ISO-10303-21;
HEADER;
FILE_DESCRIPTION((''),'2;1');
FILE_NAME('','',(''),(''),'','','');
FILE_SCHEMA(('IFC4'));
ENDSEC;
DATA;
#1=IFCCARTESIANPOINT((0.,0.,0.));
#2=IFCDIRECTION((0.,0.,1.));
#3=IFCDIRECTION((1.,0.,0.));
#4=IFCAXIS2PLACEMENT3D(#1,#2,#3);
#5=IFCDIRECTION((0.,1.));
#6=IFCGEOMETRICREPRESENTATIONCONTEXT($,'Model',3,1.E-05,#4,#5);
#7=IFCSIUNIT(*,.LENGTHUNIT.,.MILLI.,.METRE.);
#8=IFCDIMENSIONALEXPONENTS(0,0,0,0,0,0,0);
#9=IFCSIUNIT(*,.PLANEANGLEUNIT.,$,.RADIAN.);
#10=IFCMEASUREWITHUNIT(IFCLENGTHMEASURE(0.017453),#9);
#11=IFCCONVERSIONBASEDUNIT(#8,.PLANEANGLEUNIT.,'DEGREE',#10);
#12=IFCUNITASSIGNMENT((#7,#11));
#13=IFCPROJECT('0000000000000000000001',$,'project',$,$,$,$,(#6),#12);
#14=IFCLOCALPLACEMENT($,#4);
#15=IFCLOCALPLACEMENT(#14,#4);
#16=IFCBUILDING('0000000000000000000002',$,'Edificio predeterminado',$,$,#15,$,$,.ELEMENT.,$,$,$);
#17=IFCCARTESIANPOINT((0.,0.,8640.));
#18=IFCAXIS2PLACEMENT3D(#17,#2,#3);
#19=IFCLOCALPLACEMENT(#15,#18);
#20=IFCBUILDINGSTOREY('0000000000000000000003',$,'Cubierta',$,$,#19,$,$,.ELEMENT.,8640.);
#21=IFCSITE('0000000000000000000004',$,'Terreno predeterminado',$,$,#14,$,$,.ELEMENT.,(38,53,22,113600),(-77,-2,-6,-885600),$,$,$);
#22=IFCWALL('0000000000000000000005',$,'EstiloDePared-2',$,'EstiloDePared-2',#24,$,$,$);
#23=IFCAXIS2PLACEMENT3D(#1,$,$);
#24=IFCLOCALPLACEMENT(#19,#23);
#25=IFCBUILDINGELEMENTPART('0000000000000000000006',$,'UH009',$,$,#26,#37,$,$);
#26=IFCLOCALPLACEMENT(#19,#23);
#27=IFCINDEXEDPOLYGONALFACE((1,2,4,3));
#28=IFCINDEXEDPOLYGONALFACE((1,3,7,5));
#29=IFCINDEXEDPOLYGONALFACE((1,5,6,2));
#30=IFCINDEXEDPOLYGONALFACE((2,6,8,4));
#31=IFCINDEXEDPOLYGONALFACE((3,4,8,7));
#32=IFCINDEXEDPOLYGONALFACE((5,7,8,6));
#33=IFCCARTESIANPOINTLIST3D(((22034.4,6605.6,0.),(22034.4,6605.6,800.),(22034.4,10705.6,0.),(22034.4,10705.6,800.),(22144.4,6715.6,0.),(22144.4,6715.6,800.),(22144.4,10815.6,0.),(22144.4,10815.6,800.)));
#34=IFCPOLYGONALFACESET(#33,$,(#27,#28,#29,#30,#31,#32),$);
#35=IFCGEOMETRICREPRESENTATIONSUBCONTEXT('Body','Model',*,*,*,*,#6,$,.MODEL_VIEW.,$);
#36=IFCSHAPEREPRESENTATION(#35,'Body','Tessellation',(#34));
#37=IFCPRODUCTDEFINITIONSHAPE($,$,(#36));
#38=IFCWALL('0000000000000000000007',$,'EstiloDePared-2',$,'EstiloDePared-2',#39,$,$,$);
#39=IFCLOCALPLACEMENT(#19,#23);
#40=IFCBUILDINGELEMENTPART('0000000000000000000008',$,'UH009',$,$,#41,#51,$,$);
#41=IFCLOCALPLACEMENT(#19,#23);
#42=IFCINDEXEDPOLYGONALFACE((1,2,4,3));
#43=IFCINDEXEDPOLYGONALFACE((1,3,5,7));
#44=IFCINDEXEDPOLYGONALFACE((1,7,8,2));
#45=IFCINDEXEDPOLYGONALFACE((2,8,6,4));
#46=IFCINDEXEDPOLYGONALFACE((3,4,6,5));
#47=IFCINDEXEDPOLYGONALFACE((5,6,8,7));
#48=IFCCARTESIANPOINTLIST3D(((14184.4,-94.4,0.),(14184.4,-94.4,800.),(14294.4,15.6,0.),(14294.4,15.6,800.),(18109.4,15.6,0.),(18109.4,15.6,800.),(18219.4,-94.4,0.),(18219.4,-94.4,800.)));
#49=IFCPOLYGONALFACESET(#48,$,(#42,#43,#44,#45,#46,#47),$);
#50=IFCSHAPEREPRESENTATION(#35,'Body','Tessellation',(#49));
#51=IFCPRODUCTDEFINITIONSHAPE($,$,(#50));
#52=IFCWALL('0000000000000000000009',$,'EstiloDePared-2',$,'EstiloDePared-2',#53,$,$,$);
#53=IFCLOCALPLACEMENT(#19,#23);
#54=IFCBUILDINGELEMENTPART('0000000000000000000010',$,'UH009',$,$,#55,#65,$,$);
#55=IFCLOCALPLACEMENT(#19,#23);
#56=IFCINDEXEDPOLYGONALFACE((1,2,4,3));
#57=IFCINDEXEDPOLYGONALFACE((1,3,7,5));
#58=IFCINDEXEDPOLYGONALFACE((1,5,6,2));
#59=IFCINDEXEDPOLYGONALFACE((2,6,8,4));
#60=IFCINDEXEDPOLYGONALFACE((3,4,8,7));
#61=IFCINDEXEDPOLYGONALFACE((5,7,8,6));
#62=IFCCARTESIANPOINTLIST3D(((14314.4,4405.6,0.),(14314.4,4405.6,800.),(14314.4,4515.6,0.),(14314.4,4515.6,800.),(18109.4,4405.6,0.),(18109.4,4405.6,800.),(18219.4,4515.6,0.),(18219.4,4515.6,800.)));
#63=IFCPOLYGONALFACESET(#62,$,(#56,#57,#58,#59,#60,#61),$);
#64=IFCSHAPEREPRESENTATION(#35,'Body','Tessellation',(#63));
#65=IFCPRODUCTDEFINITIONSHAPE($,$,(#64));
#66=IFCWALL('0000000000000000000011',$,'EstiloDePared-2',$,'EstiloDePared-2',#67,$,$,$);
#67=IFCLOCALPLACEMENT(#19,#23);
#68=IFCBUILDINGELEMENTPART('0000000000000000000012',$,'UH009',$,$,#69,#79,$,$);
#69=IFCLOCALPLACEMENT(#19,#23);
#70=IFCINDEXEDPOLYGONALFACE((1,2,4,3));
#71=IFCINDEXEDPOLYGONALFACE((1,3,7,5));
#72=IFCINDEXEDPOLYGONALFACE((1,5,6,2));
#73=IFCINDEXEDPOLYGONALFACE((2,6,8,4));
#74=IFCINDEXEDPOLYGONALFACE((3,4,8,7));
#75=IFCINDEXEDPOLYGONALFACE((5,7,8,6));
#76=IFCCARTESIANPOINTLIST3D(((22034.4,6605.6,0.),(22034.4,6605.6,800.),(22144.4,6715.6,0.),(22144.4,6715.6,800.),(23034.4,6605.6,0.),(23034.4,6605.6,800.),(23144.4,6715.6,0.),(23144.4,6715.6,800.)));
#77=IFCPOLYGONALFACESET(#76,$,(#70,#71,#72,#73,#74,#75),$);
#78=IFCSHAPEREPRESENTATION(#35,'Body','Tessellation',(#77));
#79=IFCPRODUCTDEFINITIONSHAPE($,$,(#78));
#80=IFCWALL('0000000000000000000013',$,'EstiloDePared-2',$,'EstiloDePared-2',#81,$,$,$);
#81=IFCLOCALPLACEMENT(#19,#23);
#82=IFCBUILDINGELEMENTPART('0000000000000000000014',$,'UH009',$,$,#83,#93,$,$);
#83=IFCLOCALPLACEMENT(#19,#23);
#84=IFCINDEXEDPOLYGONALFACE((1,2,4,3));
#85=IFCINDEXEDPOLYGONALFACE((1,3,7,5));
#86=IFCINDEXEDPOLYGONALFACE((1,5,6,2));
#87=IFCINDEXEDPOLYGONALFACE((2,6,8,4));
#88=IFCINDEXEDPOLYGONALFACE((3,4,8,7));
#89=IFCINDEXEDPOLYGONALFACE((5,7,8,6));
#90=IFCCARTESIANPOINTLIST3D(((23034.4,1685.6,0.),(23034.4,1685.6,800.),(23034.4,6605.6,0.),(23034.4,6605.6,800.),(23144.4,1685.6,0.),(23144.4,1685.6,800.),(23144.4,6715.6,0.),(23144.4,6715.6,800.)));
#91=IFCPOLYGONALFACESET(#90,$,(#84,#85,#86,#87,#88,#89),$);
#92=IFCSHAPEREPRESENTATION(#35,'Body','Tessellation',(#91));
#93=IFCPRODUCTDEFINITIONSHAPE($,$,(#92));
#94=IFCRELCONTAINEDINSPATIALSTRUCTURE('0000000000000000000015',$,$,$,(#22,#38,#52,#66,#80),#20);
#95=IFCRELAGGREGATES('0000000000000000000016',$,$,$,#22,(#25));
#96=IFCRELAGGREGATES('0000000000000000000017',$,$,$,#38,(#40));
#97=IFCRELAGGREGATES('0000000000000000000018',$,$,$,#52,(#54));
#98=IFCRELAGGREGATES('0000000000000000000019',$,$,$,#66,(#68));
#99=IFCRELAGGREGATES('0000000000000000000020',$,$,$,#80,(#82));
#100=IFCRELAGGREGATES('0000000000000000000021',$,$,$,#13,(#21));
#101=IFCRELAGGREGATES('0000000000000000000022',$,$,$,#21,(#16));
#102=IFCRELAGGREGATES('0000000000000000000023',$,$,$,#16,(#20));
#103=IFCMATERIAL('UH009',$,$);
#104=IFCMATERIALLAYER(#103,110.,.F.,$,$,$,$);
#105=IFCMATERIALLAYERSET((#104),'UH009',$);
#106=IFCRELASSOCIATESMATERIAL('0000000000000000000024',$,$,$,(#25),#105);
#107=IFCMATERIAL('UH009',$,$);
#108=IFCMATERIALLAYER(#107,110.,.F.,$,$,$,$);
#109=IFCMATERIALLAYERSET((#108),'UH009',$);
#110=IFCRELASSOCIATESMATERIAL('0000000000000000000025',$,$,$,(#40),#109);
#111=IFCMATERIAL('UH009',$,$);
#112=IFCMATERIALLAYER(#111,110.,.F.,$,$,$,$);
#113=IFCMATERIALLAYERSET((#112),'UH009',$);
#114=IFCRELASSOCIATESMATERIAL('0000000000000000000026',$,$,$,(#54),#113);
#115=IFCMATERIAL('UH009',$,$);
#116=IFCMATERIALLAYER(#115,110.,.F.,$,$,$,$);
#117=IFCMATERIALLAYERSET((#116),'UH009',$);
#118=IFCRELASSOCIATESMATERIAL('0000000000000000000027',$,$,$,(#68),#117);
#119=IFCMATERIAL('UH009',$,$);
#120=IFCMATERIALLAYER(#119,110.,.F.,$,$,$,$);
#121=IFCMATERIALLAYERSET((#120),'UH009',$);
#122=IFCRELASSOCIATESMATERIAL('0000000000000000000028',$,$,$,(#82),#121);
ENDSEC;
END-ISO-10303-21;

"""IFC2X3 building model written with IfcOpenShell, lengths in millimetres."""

from ifc_helpers import new_model, entity, si_unit, converted_unit, direction, frame, origin_with_axes, place, context, subcontext, project, spatial, polyline, outline, extrude, material, layer, layer_set, layer_usage, element, aggregate, save


model = new_model("IFC2X3")

# Units and contexts
model_context = context("Model", 3, precision=1e-05, world=origin_with_axes(), true_north=direction((0.0, 1.0)))
body_context = subcontext(model_context, "Body", "Model", "MODEL_VIEW")
ifc_project = project(units=[si_unit("LENGTHUNIT", "METRE", prefix="MILLI"), converted_unit("PLANEANGLEUNIT", "DEGREE", entity("IfcLengthMeasure", 0.017453), si_unit("PLANEANGLEUNIT", "RADIAN"), dimensions=[0, 0, 0, 0, 0, 0, 0])], contexts=[model_context])

# Site, building, storey
site_placement = place(None, origin_with_axes())
site = spatial("IfcSite", under=ifc_project, at=site_placement, Name="Terreno predeterminado", CompositionType="ELEMENT", RefLatitude=(38, 53, 22, 113600), RefLongitude=(-77, -2, -6, -885600))
building_placement = place(site_placement, origin_with_axes())
building = spatial("IfcBuilding", under=site, at=building_placement, Name="Edificio predeterminado", CompositionType="ELEMENT")
storey_placement = place(building_placement, frame((0.0, 0.0, 8640.0), z_axis=(0.0, 0.0, 1.0), x_axis=(1.0, 0.0, 0.0)))
storey = spatial("IfcBuildingStorey", under=building, at=storey_placement, Name="Cubierta", CompositionType="ELEMENT", Elevation=8640.0)

# Wall, building element part
wall_1_placement = place(storey_placement, frame((22089.4, 10760.6, 0.0), z_axis=(0.0, 0.0, 1.0), x_axis=(0.0, -1.0, 0.0)))
wall_1 = element("IfcWall", 1, at=wall_1_placement, inside=storey, Name="EstiloDePared-2", ObjectType="EstiloDePared-2")
ifc_material_1 = material(Name="UH009")
ifc_layer_1 = layer(ifc_material_1, 110.0, ventilated=False)
ifc_layer_set_1 = layer_set([ifc_layer_1], Name="UH009")
ifc_layer_usage_1 = layer_usage(ifc_layer_set_1, "AXIS2", "NEGATIVE", -55.0)
building_element_part_1_placement = place(wall_1_placement, origin_with_axes())
building_element_part_1 = element("IfcBuildingElementPart", 2, at=building_element_part_1_placement, material=ifc_layer_usage_1, Name="UH009", context=body_context, shape_type="SweptSolid", body=[
    extrude(outline(polyline([(4045.0, 55.0), (4155.0, -55.0), (55.0, -55.0), (-55.0, 55.0), (4045.0, 55.0)])), origin_with_axes(), (0.0, 0.0, 1.0), 800.0),
])
aggregate(wall_1, [building_element_part_1])

# Walls, building element parts
wall_2_placement = place(storey_placement, frame((18164.4, -39.4, 0.0), z_axis=(0.0, 0.0, 1.0), x_axis=(-1.0, 0.0, 0.0)))
wall_2 = element("IfcWall", 3, at=wall_2_placement, inside=storey, Name="EstiloDePared-2", ObjectType="EstiloDePared-2")
ifc_material_2 = material(Name="UH009")
ifc_layer_2 = layer(ifc_material_2, 110.0, ventilated=False)
ifc_layer_set_2 = layer_set([ifc_layer_2], Name="UH009")
ifc_layer_usage_2 = layer_usage(ifc_layer_set_2, "AXIS2", "NEGATIVE", -55.0)
building_element_part_2_placement = place(wall_2_placement, origin_with_axes())
building_element_part_2 = element("IfcBuildingElementPart", 4, at=building_element_part_2_placement, material=ifc_layer_usage_2, Name="UH009", context=body_context, shape_type="SweptSolid", body=[
    extrude(outline(polyline([(3980.0, 55.0), (3870.0, -55.0), (55.0, -55.0), (-55.0, 55.0), (3980.0, 55.0)])), origin_with_axes(), (0.0, 0.0, 1.0), 800.0),
])
aggregate(wall_2, [building_element_part_2])
wall_3_placement = place(storey_placement, frame((18164.4, 4460.6, 0.0), z_axis=(0.0, 0.0, 1.0), x_axis=(-1.0, 0.0, 0.0)))
wall_3 = element("IfcWall", 5, at=wall_3_placement, inside=storey, Name="EstiloDePared-2", ObjectType="EstiloDePared-2")
ifc_material_3 = material(Name="UH009")
ifc_layer_3 = layer(ifc_material_3, 110.0, ventilated=False)
ifc_layer_set_3 = layer_set([ifc_layer_3], Name="UH009")
ifc_layer_usage_3 = layer_usage(ifc_layer_set_3, "AXIS2", "NEGATIVE", -55.0)
building_element_part_3_placement = place(wall_3_placement, origin_with_axes())
building_element_part_3 = element("IfcBuildingElementPart", 6, at=building_element_part_3_placement, material=ifc_layer_usage_3, Name="UH009", context=body_context, shape_type="SweptSolid", body=[
    extrude(outline(polyline([(3850.0, 55.0), (3850.0, -55.0), (-55.0, -55.0), (55.0, 55.0), (3850.0, 55.0)])), origin_with_axes(), (0.0, 0.0, 1.0), 800.0),
])
aggregate(wall_3, [building_element_part_3])
wall_4_placement = place(storey_placement, frame((22089.4, 6660.6, 0.0), z_axis=(0.0, 0.0, 1.0), x_axis=(1.0, 0.0, 0.0)))
wall_4 = element("IfcWall", 7, at=wall_4_placement, inside=storey, Name="EstiloDePared-2", ObjectType="EstiloDePared-2")
ifc_material_4 = material(Name="UH009")
ifc_layer_4 = layer(ifc_material_4, 110.0, ventilated=False)
ifc_layer_set_4 = layer_set([ifc_layer_4], Name="UH009")
ifc_layer_usage_4 = layer_usage(ifc_layer_set_4, "AXIS2", "NEGATIVE", -55.0)
building_element_part_4_placement = place(wall_4_placement, origin_with_axes())
building_element_part_4 = element("IfcBuildingElementPart", 8, at=building_element_part_4_placement, material=ifc_layer_usage_4, Name="UH009", context=body_context, shape_type="SweptSolid", body=[
    extrude(outline(polyline([(1055.0, 55.0), (945.0, -55.0), (-55.0, -55.0), (55.0, 55.0), (1055.0, 55.0)])), origin_with_axes(), (0.0, 0.0, 1.0), 800.0),
])
aggregate(wall_4, [building_element_part_4])
wall_5_placement = place(storey_placement, frame((23089.4, 6660.6, 0.0), z_axis=(0.0, 0.0, 1.0), x_axis=(0.0, -1.0, 0.0)))
wall_5 = element("IfcWall", 9, at=wall_5_placement, inside=storey, Name="EstiloDePared-2", ObjectType="EstiloDePared-2")
ifc_material_5 = material(Name="UH009")
ifc_layer_5 = layer(ifc_material_5, 110.0, ventilated=False)
ifc_layer_set_5 = layer_set([ifc_layer_5], Name="UH009")
ifc_layer_usage_5 = layer_usage(ifc_layer_set_5, "AXIS2", "NEGATIVE", -55.0)
building_element_part_5_placement = place(wall_5_placement, origin_with_axes())
building_element_part_5 = element("IfcBuildingElementPart", 10, at=building_element_part_5_placement, material=ifc_layer_usage_5, Name="UH009", context=body_context, shape_type="SweptSolid", body=[
    extrude(outline(polyline([(4975.0, 55.0), (4975.0, -55.0), (55.0, -55.0), (-55.0, 55.0), (4975.0, 55.0)])), origin_with_axes(), (0.0, 0.0, 1.0), 800.0),
])
aggregate(wall_5, [building_element_part_5])

save(model, "model.ifc")
